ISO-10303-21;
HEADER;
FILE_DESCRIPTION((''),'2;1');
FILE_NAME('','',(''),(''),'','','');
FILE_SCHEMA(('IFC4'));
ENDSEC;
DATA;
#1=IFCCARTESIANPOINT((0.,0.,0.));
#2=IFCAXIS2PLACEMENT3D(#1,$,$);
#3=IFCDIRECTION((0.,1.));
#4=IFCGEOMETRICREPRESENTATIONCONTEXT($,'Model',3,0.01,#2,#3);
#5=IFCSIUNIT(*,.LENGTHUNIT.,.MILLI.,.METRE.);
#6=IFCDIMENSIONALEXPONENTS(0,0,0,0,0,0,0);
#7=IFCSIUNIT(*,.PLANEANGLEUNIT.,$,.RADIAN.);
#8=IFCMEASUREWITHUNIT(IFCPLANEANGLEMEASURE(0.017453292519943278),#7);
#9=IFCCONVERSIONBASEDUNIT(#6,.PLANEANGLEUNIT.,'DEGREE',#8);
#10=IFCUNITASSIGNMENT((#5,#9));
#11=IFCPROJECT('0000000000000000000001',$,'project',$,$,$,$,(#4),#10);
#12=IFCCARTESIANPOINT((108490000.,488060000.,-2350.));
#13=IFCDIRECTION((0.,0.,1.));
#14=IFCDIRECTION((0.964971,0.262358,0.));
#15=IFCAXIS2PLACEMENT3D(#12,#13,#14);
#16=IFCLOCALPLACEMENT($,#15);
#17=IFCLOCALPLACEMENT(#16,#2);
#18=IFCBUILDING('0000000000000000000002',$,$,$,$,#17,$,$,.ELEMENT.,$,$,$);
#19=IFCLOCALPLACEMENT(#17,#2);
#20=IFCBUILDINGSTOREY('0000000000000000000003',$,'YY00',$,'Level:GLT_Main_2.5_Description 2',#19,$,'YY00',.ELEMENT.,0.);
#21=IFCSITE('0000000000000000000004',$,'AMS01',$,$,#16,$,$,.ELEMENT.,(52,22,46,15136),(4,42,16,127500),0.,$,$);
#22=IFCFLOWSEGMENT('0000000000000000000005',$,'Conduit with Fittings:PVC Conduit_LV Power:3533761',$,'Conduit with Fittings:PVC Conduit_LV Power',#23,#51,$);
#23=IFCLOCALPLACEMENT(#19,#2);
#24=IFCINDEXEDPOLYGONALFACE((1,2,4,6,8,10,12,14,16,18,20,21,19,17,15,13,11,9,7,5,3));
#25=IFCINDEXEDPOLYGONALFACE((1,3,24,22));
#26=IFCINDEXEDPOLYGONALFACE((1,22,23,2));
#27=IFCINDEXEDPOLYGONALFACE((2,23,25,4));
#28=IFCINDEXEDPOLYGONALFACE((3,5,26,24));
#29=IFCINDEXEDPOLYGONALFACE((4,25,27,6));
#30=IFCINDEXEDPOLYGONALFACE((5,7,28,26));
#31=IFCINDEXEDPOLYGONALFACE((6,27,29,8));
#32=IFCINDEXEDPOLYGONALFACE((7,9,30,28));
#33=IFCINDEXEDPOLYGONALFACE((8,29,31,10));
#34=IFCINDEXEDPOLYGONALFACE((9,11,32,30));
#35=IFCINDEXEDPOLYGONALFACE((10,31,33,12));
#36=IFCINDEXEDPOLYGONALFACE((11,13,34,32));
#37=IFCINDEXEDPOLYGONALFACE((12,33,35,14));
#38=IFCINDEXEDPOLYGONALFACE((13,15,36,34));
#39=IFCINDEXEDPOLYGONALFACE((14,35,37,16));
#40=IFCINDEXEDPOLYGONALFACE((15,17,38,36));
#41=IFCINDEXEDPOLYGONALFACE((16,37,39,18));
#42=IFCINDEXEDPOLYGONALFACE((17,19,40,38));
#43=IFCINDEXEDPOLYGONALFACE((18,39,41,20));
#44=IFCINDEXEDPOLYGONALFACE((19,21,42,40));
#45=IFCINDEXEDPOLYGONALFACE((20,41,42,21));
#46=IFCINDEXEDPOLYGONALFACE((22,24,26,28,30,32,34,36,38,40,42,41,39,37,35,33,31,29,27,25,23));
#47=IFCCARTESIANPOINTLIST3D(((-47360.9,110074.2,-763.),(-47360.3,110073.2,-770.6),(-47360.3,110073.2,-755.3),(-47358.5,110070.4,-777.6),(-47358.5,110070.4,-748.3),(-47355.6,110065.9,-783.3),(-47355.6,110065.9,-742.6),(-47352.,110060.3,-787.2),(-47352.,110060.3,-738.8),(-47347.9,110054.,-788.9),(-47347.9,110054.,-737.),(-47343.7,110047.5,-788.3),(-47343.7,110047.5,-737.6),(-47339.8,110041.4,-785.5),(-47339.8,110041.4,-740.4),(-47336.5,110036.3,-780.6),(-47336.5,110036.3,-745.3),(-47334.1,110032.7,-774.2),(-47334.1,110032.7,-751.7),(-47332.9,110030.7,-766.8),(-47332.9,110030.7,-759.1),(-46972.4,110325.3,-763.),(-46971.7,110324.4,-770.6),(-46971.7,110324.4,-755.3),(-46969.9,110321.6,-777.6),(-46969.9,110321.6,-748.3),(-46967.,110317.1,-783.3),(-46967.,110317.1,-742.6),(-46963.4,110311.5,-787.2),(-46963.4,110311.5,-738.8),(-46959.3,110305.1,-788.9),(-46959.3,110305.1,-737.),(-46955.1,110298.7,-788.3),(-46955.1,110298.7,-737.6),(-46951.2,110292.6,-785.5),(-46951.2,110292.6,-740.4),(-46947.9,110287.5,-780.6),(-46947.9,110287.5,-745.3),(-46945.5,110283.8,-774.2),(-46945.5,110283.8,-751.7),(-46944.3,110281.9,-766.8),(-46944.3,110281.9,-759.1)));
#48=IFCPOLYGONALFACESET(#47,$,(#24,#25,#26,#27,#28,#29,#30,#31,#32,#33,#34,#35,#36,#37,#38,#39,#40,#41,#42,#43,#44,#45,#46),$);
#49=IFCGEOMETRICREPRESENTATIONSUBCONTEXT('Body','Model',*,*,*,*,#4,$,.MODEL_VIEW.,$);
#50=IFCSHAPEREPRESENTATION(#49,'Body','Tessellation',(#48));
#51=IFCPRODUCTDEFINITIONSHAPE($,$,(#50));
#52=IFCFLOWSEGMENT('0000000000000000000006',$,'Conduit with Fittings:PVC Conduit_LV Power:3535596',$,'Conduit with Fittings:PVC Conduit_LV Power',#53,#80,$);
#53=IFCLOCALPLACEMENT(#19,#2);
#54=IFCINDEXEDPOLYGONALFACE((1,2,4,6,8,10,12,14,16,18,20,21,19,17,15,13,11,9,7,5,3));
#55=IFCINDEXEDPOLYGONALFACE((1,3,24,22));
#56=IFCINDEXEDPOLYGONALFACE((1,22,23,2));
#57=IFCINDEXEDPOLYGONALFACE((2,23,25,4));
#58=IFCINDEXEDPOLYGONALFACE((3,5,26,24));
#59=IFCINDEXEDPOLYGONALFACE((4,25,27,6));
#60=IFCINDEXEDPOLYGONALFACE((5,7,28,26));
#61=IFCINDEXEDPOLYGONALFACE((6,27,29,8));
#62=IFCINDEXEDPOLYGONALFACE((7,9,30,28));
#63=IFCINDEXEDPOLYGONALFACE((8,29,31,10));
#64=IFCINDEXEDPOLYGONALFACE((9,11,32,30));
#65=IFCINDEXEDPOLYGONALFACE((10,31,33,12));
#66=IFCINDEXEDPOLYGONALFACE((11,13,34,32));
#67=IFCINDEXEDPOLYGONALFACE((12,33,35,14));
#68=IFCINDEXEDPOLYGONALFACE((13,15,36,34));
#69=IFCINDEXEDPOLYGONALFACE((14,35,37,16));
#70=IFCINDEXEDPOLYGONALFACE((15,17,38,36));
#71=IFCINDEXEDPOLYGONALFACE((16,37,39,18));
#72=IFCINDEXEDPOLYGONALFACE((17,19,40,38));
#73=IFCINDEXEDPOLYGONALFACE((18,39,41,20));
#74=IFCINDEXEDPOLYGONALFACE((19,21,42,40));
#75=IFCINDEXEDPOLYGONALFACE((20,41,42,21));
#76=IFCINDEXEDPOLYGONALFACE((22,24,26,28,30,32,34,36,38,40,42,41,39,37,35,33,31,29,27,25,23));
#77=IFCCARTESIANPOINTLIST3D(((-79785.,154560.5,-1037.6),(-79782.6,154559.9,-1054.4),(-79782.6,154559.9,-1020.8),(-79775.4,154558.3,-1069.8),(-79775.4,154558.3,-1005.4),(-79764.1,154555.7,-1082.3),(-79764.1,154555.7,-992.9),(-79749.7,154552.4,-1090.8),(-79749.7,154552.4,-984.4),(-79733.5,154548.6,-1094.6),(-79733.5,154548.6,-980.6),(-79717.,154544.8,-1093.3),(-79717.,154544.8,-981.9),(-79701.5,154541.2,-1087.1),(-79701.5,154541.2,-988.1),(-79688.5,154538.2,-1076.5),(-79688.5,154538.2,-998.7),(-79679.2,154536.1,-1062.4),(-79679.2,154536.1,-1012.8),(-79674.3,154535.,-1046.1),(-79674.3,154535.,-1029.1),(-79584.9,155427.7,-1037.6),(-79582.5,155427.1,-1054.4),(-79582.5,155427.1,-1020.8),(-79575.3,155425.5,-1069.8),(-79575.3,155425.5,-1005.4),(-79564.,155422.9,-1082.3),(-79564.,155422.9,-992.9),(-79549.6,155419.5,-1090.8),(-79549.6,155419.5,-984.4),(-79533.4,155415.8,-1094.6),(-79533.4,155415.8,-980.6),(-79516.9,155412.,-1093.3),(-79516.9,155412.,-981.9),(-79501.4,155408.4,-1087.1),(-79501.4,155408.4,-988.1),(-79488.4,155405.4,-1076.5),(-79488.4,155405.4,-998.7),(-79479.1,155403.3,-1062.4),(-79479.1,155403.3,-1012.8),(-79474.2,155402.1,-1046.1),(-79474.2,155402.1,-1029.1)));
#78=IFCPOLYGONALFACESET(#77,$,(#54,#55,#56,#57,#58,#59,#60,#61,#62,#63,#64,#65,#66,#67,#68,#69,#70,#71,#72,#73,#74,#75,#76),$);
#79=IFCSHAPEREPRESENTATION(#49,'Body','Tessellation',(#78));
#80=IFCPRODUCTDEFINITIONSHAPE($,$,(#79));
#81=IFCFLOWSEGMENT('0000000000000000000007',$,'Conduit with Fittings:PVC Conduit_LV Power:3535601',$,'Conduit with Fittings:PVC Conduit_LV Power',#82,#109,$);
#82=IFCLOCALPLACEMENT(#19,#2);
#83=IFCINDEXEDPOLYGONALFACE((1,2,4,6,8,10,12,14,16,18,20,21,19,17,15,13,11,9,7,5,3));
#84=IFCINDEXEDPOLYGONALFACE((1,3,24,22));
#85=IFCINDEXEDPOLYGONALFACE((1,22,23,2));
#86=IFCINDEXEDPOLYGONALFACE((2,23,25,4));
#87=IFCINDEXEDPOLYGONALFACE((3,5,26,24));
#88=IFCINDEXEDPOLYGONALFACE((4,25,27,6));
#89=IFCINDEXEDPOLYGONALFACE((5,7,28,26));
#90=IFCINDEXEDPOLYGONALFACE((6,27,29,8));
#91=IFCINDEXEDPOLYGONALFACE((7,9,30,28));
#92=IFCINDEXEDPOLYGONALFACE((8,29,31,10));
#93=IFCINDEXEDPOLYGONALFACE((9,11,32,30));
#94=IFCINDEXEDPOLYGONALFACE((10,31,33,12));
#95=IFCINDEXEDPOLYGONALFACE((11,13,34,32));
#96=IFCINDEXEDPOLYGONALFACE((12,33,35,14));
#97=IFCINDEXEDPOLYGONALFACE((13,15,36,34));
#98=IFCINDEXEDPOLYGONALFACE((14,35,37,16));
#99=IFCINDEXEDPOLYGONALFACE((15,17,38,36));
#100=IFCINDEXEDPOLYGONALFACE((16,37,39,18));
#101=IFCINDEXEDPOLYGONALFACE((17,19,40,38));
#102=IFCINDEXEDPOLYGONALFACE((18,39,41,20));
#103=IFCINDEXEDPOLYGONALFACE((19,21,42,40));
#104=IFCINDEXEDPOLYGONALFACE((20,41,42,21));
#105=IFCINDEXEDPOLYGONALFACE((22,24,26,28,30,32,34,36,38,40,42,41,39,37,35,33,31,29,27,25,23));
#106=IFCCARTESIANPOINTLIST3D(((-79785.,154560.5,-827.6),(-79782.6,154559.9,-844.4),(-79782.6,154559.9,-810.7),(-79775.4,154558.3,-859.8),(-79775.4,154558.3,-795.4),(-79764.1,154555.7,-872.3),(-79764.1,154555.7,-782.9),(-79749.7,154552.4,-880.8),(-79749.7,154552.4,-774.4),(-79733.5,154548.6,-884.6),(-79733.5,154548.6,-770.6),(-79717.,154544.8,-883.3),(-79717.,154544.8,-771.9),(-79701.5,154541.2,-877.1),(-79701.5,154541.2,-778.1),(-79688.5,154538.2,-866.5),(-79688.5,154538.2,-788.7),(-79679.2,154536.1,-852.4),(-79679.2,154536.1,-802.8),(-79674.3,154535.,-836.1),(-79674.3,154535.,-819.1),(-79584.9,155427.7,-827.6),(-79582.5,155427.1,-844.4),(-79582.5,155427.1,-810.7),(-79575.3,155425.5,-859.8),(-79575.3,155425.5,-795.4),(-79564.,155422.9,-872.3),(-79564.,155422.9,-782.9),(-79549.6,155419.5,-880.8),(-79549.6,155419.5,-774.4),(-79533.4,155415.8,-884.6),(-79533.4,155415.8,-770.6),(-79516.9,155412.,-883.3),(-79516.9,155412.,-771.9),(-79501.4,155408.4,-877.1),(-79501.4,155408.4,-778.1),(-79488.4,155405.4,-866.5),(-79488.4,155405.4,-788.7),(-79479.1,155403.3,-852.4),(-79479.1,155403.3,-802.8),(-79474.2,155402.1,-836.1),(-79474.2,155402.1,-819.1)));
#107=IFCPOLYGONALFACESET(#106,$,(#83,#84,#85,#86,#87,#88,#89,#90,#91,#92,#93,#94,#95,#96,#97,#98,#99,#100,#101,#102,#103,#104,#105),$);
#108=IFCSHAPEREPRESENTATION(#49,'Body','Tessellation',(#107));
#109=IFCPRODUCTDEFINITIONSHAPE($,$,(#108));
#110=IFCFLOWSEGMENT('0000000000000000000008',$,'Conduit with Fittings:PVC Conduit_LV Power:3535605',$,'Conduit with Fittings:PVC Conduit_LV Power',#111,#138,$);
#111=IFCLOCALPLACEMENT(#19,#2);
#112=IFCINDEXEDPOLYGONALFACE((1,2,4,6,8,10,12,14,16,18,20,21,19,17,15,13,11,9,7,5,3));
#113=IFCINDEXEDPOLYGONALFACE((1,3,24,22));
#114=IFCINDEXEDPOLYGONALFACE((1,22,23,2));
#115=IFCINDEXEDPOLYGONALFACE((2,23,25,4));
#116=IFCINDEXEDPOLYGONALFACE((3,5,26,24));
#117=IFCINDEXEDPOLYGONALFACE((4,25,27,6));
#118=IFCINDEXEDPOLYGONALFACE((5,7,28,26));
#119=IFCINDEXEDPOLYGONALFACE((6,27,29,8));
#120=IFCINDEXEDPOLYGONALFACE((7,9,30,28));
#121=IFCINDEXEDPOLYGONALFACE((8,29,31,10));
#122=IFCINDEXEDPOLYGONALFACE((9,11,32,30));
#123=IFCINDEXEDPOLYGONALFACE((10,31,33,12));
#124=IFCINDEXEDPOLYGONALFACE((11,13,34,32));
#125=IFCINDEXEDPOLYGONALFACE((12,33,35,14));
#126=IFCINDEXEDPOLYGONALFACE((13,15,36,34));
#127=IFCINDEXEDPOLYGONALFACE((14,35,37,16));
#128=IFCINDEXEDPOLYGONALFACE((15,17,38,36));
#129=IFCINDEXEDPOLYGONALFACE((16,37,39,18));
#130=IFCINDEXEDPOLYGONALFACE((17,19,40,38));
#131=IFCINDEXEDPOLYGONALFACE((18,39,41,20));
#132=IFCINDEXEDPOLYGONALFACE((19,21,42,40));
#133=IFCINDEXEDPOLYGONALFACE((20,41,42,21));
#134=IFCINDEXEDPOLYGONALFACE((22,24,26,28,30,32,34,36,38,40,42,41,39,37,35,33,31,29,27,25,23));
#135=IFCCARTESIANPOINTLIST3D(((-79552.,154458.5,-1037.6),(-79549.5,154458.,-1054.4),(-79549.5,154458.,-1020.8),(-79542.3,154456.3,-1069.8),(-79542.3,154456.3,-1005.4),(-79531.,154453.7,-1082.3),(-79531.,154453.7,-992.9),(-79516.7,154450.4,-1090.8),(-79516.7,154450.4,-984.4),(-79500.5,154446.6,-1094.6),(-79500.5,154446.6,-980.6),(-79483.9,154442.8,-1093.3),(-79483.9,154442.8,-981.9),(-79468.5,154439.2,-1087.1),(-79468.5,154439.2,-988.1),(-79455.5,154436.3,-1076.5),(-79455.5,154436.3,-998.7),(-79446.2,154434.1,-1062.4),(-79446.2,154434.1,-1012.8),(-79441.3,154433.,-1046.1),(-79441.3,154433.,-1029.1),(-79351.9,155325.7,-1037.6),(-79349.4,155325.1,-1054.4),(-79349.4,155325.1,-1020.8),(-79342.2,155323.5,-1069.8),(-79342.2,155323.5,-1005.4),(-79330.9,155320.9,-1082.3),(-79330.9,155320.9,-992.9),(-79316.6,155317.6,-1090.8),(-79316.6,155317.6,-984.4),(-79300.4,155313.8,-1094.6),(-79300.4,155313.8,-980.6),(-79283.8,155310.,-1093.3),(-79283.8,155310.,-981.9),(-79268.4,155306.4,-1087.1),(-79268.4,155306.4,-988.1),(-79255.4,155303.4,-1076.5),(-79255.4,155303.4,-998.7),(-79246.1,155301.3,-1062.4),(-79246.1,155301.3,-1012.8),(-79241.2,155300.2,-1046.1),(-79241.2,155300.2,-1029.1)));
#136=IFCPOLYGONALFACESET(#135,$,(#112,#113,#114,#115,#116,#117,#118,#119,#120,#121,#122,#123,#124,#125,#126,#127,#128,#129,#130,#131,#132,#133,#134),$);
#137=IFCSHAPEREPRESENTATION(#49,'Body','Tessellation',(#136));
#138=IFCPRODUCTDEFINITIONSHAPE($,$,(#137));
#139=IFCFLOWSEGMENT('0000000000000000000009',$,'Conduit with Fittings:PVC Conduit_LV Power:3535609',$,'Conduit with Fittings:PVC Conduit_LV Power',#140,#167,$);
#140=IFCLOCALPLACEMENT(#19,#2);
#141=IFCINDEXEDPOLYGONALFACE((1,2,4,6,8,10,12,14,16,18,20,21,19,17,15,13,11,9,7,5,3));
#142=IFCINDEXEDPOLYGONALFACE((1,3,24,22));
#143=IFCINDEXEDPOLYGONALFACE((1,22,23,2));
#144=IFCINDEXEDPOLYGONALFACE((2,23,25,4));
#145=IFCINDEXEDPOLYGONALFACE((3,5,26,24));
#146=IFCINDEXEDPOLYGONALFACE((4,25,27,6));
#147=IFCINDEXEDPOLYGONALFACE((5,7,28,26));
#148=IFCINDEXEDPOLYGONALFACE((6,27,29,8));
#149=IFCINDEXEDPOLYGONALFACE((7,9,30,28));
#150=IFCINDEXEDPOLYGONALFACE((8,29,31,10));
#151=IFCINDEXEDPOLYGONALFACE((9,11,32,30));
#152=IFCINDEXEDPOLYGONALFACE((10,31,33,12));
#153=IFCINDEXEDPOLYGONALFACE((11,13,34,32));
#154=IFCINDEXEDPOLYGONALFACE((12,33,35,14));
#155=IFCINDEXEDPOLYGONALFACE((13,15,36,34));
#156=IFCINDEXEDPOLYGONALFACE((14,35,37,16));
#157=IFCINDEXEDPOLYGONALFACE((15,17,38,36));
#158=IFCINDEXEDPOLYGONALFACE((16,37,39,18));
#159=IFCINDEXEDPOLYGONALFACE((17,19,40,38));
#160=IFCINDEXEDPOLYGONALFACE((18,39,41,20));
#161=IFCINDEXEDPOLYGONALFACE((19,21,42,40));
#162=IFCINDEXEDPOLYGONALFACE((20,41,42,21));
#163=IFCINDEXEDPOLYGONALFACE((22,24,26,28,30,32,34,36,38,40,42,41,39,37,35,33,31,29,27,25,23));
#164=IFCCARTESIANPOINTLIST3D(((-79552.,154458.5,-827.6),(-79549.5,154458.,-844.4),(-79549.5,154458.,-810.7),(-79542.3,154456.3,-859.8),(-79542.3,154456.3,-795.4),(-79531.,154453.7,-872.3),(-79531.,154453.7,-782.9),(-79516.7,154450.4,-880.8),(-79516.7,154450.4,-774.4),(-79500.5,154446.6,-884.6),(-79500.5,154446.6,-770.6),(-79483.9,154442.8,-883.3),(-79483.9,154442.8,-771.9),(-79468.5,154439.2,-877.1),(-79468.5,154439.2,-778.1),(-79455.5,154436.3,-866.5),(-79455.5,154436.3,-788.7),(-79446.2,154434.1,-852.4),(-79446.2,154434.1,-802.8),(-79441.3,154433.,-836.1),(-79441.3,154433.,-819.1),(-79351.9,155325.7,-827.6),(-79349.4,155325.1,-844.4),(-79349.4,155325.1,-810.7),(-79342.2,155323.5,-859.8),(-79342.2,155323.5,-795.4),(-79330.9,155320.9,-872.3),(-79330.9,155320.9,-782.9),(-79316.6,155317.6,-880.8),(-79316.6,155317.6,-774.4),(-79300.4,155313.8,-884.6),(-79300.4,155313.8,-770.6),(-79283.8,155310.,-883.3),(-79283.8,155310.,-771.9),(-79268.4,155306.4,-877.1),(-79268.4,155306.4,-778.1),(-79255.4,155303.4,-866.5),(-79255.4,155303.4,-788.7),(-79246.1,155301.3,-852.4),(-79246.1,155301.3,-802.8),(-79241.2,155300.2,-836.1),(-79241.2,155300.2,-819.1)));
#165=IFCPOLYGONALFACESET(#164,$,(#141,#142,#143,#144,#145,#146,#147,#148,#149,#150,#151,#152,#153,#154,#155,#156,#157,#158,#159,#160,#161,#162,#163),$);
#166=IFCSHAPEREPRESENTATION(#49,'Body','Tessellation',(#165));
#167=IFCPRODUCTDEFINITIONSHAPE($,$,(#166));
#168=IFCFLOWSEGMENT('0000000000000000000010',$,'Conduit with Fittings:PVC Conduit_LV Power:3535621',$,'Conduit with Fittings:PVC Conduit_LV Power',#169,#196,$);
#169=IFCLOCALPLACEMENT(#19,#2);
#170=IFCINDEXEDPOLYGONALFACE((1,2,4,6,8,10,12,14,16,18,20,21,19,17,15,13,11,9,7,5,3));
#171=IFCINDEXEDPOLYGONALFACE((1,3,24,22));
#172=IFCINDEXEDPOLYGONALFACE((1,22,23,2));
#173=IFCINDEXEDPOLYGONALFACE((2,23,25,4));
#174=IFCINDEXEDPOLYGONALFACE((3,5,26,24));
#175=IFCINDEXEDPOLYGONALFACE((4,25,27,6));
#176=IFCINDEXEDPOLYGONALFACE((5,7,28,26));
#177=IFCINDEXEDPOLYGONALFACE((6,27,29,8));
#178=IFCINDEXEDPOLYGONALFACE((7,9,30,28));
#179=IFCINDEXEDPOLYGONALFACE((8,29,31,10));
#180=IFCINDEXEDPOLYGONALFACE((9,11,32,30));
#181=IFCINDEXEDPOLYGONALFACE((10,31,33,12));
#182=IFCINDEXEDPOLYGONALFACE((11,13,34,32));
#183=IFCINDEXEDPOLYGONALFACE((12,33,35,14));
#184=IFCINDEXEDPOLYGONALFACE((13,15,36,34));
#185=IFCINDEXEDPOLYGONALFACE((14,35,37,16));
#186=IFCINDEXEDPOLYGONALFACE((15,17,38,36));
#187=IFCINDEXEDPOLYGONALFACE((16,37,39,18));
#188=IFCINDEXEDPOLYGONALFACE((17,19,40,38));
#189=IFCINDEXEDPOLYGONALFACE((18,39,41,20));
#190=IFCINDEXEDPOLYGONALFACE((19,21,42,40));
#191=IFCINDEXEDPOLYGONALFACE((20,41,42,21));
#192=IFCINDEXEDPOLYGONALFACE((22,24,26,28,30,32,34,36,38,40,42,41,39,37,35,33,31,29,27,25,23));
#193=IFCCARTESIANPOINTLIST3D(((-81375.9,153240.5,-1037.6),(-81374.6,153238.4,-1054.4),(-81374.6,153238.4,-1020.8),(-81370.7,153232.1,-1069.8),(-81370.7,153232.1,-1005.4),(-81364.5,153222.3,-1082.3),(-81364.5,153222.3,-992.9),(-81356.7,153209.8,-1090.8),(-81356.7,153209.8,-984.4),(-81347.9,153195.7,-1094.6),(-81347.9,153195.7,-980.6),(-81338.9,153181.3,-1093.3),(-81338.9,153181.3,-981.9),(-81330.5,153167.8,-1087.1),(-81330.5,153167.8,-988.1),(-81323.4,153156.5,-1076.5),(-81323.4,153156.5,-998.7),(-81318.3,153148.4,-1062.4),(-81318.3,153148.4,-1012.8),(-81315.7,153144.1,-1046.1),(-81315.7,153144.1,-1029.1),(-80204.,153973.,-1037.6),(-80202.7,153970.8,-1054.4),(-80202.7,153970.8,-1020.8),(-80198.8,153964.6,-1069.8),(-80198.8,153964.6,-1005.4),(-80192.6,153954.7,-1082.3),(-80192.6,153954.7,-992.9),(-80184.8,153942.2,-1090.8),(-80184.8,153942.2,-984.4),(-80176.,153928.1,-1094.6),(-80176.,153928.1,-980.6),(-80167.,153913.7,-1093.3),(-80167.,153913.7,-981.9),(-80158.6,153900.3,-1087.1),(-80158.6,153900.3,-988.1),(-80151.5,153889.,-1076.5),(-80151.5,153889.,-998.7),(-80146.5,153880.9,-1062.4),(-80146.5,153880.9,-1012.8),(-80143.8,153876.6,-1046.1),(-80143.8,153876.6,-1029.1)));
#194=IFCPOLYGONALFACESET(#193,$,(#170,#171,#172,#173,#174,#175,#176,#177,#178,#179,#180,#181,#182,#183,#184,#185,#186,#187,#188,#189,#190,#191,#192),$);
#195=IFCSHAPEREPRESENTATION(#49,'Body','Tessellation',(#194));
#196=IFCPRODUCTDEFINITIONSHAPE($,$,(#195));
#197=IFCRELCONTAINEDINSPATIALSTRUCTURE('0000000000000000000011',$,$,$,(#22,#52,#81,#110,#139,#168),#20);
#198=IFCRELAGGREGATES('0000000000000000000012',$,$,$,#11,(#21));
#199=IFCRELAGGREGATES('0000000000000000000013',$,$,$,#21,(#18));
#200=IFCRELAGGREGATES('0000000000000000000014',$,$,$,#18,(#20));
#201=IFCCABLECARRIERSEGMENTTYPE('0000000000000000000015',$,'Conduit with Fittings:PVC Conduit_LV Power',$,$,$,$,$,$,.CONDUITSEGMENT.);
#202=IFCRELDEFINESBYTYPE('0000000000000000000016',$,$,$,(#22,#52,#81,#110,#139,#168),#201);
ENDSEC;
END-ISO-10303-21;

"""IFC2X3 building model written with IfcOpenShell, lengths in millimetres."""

from ifc_helpers import new_model, entity, si_unit, converted_unit, direction, frame, frame_2d, origin, origin_2d_with_axis, place, context, subcontext, project, spatial, circle, extrude, type_object, element, save


model = new_model("IFC2X3")

# Units and contexts
model_context = context("Model", 3, precision=0.01, world=origin(), true_north=direction((0.0, 1.0)))
body_context = subcontext(model_context, "Body", "Model", "MODEL_VIEW")
ifc_project = project(units=[si_unit("LENGTHUNIT", "METRE", prefix="MILLI"), converted_unit("PLANEANGLEUNIT", "DEGREE", entity("IfcPlaneAngleMeasure", 0.017453292519943278), si_unit("PLANEANGLEUNIT", "RADIAN"), dimensions=[0, 0, 0, 0, 0, 0, 0])], contexts=[model_context])

# Site, building, storey
site_placement = place(None, frame((108490000.0, 488060000.0, -2350.0), z_axis=(0.0, 0.0, 1.0), x_axis=(0.964971, 0.262358, 0.0)))
site = spatial("IfcSite", under=ifc_project, at=site_placement, Name="AMS01", CompositionType="ELEMENT", RefLatitude=(52, 22, 46, 15136), RefLongitude=(4, 42, 16, 127500), RefElevation=0.0)
building_placement = place(site_placement, origin())
building = spatial("IfcBuilding", under=site, at=building_placement, CompositionType="ELEMENT")
storey_placement = place(building_placement, origin())
storey = spatial("IfcBuildingStorey", under=building, at=storey_placement, Name="YY00", ObjectType="Level:GLT_Main_2.5_Description 2", LongName="YY00", CompositionType="ELEMENT", Elevation=0.0)

# Flow segments
cable_carrier_segment_type = type_object("IfcCableCarrierSegmentType", Name="Conduit with Fittings:PVC Conduit_LV Power", PredefinedType="CONDUITSEGMENT")
flow_segment_1_placement = place(storey_placement, origin())
element("IfcFlowSegment", 1, at=flow_segment_1_placement, inside=storey, type_object=cable_carrier_segment_type, Name="Conduit with Fittings:PVC Conduit_LV Power:3533761", ObjectType="Conduit with Fittings:PVC Conduit_LV Power", context=body_context, shape_type="SweptSolid", body=[
    extrude(circle(Radius=26.0, at=frame_2d((0.0, 0.0), x_axis=(1.0, 0.0))), frame((-47346.8, 110052.3, -763.0), z_axis=(0.839826, 0.542856, 0.0), x_axis=(-0.542856, 0.839826, 0.0)), (0.0, 0.0, 1.0), 462.7),
])
flow_segment_2_placement = place(storey_placement, origin())
element("IfcFlowSegment", 2, at=flow_segment_2_placement, inside=storey, type_object=cable_carrier_segment_type, Name="Conduit with Fittings:PVC Conduit_LV Power:3535596", ObjectType="Conduit with Fittings:PVC Conduit_LV Power", context=body_context, shape_type="SweptSolid", body=[
    extrude(circle(Radius=57.2, at=origin_2d_with_axis()), frame((-79729.4, 154547.7, -1037.6), z_axis=(0.224839, 0.974396, 0.0), x_axis=(-0.974396, 0.224839, 0.0)), (0.0, 0.0, 1.0), 890.0),
])
flow_segment_3_placement = place(storey_placement, origin())
element("IfcFlowSegment", 3, at=flow_segment_3_placement, inside=storey, type_object=cable_carrier_segment_type, Name="Conduit with Fittings:PVC Conduit_LV Power:3535601", ObjectType="Conduit with Fittings:PVC Conduit_LV Power", context=body_context, shape_type="SweptSolid", body=[
    extrude(circle(Radius=57.2, at=frame_2d((0.0, 0.0), x_axis=(1.0, 0.0))), frame((-79729.4, 154547.7, -827.6), z_axis=(0.224839, 0.974396, 0.0), x_axis=(-0.974396, 0.224839, 0.0)), (0.0, 0.0, 1.0), 890.0),
])
flow_segment_4_placement = place(storey_placement, origin())
element("IfcFlowSegment", 4, at=flow_segment_4_placement, inside=storey, type_object=cable_carrier_segment_type, Name="Conduit with Fittings:PVC Conduit_LV Power:3535605", ObjectType="Conduit with Fittings:PVC Conduit_LV Power", context=body_context, shape_type="SweptSolid", body=[
    extrude(circle(Radius=57.2, at=origin_2d_with_axis()), frame((-79496.3, 154445.7, -1037.6), z_axis=(0.224839, 0.974396, 0.0), x_axis=(-0.974396, 0.224839, 0.0)), (0.0, 0.0, 1.0), 890.0),
])
flow_segment_5_placement = place(storey_placement, origin())
element("IfcFlowSegment", 5, at=flow_segment_5_placement, inside=storey, type_object=cable_carrier_segment_type, Name="Conduit with Fittings:PVC Conduit_LV Power:3535609", ObjectType="Conduit with Fittings:PVC Conduit_LV Power", context=body_context, shape_type="SweptSolid", body=[
    extrude(circle(Radius=57.2, at=frame_2d((0.0, 0.0), x_axis=(1.0, 0.0))), frame((-79496.3, 154445.7, -827.6), z_axis=(0.224839, 0.974396, 0.0), x_axis=(-0.974396, 0.224839, 0.0)), (0.0, 0.0, 1.0), 890.0),
])
flow_segment_6_placement = place(storey_placement, origin())
element("IfcFlowSegment", 6, at=flow_segment_6_placement, inside=storey, type_object=cable_carrier_segment_type, Name="Conduit with Fittings:PVC Conduit_LV Power:3535621", ObjectType="Conduit with Fittings:PVC Conduit_LV Power", context=body_context, shape_type="SweptSolid", body=[
    extrude(circle(Radius=57.2, at=frame_2d((0.0, 0.0), x_axis=(1.0, 0.0))), frame((-81345.6, 153192.0, -1037.6), z_axis=(0.847987, 0.530017, 0.0), x_axis=(-0.530017, 0.847987, 0.0)), (0.0, 0.0, 1.0), 1382.0),
])

save(model, "model.ifc")
